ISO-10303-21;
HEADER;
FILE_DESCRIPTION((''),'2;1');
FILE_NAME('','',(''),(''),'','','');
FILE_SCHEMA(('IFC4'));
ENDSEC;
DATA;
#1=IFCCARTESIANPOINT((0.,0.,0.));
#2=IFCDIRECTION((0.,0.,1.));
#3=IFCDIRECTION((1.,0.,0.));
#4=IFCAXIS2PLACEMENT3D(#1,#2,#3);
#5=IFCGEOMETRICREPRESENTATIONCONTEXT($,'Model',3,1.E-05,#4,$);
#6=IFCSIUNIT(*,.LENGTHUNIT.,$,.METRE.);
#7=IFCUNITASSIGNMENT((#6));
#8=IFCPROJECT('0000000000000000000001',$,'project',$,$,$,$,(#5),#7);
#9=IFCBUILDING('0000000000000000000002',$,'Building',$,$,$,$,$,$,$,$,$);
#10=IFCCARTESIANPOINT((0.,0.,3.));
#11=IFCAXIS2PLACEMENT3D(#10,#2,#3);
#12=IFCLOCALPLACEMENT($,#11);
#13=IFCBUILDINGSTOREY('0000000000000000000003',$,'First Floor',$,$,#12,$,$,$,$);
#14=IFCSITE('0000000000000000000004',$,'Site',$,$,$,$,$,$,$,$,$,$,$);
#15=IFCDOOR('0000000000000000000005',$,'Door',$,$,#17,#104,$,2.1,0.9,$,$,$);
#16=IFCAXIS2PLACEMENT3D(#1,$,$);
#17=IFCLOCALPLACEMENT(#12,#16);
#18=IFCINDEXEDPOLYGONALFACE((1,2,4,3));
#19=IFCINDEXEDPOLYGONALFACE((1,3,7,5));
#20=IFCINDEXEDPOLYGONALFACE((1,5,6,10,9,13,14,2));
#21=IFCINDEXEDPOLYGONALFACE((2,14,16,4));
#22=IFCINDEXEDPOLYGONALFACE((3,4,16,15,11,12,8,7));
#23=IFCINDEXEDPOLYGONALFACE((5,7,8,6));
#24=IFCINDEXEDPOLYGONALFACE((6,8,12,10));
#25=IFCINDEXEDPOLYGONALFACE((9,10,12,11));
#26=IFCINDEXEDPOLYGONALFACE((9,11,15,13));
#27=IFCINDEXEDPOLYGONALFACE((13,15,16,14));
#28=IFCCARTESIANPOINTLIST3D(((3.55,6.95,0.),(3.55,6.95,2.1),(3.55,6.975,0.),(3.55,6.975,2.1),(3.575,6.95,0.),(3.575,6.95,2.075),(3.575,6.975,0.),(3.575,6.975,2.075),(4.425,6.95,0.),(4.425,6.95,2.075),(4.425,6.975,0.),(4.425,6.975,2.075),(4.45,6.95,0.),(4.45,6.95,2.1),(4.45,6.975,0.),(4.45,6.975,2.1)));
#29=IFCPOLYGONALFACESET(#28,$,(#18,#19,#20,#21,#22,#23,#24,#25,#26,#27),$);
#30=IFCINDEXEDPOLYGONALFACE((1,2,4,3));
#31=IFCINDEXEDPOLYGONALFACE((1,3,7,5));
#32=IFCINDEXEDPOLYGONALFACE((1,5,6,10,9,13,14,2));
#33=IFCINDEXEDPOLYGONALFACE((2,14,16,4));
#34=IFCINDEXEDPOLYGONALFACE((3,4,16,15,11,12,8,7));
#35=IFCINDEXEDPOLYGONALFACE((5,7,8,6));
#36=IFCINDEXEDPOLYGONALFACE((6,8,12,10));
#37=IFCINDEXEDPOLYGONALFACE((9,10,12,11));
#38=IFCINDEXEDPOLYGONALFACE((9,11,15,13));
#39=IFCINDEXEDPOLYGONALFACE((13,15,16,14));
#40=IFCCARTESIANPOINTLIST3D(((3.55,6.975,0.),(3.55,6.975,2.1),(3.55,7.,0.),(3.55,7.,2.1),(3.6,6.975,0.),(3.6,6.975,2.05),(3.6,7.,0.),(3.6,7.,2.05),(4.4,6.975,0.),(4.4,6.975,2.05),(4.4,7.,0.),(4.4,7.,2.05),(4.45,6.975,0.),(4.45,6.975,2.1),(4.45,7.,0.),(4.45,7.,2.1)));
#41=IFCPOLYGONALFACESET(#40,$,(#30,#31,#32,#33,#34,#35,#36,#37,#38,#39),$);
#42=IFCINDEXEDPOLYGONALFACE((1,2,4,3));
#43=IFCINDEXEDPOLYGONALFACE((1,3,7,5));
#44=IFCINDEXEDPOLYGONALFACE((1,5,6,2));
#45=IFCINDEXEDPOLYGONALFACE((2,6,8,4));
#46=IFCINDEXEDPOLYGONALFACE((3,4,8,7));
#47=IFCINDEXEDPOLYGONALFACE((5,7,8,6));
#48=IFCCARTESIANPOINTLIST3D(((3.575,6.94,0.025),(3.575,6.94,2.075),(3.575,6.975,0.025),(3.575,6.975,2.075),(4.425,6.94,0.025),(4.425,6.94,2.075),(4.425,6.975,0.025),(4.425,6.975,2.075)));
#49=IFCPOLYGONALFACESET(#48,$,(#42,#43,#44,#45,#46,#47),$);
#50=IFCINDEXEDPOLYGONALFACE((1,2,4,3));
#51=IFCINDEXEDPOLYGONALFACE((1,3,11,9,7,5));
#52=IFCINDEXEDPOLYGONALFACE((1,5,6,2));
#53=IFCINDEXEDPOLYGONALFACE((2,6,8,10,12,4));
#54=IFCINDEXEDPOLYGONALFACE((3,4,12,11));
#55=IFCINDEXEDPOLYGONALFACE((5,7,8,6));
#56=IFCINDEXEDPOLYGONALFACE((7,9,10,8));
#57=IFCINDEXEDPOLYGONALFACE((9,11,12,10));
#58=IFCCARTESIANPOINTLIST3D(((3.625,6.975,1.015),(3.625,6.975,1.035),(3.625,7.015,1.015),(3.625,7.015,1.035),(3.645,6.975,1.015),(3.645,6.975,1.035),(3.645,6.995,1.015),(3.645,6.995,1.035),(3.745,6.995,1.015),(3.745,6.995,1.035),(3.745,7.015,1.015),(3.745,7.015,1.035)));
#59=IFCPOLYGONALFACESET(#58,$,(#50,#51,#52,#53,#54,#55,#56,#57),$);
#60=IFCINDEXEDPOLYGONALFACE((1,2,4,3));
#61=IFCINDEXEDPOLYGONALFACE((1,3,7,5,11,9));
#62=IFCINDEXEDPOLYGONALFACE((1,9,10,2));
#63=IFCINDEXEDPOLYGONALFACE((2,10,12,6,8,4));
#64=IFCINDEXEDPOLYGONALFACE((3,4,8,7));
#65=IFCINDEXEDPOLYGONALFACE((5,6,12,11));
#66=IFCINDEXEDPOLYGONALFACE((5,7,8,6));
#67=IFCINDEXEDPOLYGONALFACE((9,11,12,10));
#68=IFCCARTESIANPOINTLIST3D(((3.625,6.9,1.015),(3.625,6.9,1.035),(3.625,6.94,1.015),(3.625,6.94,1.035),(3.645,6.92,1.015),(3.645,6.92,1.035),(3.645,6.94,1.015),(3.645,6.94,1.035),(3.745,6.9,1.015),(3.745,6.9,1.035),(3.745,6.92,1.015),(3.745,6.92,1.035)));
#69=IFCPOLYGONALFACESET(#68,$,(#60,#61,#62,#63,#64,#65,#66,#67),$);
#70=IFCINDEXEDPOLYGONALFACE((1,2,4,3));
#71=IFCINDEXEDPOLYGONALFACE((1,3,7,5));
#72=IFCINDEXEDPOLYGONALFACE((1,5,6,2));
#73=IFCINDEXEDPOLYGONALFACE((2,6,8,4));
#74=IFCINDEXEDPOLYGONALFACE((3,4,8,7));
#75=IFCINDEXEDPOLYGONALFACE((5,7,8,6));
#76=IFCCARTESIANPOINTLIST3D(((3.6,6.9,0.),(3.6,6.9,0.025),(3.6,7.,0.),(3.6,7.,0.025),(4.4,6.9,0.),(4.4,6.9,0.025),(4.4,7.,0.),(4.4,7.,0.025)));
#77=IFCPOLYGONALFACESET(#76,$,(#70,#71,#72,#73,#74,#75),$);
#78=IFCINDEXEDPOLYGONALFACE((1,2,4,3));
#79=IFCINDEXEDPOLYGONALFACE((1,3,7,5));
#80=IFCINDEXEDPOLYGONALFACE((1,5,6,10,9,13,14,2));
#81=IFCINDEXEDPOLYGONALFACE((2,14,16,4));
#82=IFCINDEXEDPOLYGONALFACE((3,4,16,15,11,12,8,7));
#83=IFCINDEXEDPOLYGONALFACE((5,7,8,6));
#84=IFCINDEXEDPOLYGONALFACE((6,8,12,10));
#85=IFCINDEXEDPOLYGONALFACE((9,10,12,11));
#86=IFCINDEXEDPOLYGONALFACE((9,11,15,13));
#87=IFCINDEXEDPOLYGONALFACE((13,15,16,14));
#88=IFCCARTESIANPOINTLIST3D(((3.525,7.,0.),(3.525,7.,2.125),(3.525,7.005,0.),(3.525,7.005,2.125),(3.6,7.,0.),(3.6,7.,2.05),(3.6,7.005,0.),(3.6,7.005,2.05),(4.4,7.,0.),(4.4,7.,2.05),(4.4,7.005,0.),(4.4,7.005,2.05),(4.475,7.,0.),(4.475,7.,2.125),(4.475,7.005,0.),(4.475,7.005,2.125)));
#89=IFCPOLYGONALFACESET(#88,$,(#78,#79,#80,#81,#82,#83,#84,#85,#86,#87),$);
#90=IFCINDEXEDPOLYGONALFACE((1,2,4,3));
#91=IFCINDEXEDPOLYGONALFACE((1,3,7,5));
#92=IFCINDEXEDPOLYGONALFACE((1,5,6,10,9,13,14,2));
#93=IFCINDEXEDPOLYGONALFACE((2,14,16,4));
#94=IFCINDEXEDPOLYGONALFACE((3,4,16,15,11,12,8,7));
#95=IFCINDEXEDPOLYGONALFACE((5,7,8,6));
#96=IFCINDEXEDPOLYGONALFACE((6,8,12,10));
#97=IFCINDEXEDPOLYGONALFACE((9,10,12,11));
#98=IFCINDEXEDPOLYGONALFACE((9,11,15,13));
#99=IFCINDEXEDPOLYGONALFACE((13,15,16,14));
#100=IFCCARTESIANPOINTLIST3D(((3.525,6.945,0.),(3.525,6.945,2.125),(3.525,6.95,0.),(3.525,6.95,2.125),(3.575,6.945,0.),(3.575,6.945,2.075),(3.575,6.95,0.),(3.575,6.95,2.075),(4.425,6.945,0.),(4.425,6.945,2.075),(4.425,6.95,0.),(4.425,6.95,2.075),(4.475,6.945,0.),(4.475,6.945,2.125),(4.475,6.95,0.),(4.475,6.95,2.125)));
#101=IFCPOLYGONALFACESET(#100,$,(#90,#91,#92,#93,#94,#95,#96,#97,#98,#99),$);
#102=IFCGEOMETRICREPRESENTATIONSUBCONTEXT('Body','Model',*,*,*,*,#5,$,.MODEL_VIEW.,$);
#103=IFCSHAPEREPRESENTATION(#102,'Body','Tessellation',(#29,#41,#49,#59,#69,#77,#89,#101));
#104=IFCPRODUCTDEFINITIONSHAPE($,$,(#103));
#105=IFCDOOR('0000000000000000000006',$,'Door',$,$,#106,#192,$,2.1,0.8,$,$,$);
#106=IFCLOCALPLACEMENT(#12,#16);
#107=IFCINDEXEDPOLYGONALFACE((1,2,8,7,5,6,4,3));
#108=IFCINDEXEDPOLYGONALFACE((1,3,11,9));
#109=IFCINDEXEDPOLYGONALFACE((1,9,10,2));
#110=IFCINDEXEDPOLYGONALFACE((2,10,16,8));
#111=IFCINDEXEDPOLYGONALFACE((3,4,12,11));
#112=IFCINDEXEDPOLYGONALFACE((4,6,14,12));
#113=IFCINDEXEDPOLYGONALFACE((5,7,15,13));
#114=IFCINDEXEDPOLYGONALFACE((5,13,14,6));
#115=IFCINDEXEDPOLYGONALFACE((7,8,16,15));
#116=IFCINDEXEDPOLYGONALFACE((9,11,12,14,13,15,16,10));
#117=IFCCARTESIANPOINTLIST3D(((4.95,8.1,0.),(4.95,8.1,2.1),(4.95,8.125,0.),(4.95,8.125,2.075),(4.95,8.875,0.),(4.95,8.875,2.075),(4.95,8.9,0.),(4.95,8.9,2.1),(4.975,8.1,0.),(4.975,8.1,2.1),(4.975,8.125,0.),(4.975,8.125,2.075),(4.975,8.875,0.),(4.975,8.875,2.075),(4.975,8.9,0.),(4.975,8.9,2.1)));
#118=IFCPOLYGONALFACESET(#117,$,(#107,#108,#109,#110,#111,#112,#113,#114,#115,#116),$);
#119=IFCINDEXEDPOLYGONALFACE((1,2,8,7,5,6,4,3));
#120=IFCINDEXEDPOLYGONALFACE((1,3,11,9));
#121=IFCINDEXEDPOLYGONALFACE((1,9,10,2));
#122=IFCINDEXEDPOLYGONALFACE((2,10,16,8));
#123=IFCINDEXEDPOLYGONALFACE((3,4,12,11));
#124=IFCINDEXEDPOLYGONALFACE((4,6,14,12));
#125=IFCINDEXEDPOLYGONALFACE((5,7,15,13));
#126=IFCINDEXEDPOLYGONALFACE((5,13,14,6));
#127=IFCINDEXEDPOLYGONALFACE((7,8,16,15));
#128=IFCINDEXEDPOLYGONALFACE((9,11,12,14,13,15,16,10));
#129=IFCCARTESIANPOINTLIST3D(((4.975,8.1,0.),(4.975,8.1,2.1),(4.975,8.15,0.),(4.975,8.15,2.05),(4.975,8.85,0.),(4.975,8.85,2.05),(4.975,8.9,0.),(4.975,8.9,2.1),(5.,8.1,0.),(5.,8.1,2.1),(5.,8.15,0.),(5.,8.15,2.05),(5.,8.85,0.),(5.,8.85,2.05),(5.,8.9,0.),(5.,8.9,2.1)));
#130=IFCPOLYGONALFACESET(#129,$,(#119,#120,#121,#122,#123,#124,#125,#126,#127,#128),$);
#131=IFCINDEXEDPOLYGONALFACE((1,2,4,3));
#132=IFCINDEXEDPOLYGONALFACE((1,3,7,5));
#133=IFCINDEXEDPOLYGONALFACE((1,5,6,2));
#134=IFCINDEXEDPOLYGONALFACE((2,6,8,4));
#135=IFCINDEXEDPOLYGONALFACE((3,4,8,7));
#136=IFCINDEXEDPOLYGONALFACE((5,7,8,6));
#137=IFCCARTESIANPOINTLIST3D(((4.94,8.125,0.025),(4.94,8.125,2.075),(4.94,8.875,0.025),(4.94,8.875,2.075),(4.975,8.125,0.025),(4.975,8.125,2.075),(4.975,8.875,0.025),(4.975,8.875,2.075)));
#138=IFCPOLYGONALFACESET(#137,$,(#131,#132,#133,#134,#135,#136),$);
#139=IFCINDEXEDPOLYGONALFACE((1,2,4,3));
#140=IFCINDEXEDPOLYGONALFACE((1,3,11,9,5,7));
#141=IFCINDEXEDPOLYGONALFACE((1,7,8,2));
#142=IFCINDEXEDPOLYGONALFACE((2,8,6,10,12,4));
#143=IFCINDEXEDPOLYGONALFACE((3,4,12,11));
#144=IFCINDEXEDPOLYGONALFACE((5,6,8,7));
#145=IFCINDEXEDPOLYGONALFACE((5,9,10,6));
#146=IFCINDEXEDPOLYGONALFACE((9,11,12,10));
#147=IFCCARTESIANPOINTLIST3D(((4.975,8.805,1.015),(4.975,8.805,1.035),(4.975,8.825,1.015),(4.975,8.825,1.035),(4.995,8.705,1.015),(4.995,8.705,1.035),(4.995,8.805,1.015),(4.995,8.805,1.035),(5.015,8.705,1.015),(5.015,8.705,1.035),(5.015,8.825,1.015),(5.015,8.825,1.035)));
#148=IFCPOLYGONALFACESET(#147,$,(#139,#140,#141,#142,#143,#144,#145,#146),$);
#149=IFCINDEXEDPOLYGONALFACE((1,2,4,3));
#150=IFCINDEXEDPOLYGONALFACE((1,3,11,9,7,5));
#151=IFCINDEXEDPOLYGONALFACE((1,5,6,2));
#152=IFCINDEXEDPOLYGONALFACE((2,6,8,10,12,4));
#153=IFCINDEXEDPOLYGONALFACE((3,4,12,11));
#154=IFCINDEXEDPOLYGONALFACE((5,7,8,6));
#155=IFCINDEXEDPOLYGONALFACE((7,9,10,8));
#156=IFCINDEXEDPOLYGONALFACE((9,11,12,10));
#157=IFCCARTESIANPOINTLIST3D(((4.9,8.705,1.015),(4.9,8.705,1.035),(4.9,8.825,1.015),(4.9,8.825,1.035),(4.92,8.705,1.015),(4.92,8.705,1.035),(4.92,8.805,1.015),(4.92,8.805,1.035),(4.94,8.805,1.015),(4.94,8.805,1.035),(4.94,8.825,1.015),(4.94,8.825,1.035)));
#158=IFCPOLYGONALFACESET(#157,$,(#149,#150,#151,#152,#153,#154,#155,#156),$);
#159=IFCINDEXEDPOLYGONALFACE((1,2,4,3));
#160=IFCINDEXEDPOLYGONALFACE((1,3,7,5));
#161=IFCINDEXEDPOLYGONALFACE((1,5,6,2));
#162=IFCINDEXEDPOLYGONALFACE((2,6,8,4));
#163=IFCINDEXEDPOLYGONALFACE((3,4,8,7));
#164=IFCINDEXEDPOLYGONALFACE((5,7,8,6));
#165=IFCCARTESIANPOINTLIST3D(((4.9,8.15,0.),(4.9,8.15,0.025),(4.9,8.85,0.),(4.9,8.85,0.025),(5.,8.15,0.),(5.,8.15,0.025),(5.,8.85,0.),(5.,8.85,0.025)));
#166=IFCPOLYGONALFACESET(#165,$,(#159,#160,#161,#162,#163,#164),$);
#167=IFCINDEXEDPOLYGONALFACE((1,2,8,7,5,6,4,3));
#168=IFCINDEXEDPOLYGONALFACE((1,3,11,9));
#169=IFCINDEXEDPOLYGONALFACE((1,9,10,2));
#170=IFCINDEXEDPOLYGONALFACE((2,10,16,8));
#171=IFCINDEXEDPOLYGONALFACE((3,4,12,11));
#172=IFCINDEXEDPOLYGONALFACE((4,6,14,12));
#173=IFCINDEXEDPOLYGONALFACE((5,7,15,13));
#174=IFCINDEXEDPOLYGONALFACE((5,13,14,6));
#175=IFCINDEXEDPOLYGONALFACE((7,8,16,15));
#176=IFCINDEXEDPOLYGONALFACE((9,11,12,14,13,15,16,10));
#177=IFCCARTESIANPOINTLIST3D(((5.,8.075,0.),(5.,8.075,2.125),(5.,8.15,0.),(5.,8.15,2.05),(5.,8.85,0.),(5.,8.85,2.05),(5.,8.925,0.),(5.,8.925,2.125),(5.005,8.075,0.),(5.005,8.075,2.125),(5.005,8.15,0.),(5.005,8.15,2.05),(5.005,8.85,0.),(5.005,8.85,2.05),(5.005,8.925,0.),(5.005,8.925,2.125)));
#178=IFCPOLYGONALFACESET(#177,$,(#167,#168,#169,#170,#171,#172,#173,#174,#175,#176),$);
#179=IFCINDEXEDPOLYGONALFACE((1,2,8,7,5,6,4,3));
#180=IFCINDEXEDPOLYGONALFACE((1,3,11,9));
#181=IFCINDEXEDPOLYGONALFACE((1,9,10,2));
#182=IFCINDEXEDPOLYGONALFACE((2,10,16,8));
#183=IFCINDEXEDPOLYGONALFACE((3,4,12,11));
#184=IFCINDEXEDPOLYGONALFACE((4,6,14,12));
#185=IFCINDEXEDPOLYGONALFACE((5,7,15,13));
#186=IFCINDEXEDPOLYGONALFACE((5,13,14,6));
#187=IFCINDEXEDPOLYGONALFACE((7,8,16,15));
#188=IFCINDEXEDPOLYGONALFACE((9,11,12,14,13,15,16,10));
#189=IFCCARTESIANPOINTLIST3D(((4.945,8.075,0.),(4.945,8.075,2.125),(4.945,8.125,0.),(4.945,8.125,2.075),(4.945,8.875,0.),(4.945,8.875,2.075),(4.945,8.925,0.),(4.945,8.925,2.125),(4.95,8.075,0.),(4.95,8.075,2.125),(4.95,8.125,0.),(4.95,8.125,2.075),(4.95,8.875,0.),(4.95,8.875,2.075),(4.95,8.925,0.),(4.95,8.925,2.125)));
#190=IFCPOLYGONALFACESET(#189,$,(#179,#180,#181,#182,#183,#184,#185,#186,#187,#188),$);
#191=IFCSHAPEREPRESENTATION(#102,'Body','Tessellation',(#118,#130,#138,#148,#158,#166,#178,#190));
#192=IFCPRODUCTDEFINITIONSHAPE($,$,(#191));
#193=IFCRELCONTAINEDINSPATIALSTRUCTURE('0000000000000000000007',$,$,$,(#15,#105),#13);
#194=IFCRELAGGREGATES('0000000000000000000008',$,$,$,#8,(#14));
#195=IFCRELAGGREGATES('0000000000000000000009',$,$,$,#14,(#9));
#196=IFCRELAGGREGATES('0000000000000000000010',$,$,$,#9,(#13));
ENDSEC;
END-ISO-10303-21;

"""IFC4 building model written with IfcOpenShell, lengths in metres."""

from ifc_helpers import new_model, si_unit, frame, origin_with_axes, place, context, subcontext, project, spatial, line, indexed_curve, outline, extrude, element, save


model = new_model("IFC4")

# Units and contexts
model_context = context("Model", 3, precision=1e-05, world=origin_with_axes())
body_context = subcontext(model_context, "Body", "Model", "MODEL_VIEW")
ifc_project = project(units=[si_unit("LENGTHUNIT", "METRE")], contexts=[model_context])

# Site, building, storey
site = spatial("IfcSite", under=ifc_project, Name="Site")
building = spatial("IfcBuilding", under=site, Name="Building")
storey_placement = place(None, frame((0.0, 0.0, 3.0), z_axis=(0.0, 0.0, 1.0), x_axis=(1.0, 0.0, 0.0)))
storey = spatial("IfcBuildingStorey", under=building, at=storey_placement, Name="First Floor")

# Doors
door_1_placement = place(storey_placement, frame((4.45, 7.0, 0.0), z_axis=(0.0, 0.0, 1.0), x_axis=(-1.0, 0.0, 0.0)))
element("IfcDoor", 1, at=door_1_placement, inside=storey, Name="Door", OverallHeight=2.1, OverallWidth=0.9, context=body_context, shape_type="SweptSolid", body=[
    extrude(outline(indexed_curve([(0.0, 0.0), (0.0, 2.1), (0.9, 2.1), (0.9, 0.0), (0.875, 0.0), (0.875, 2.075), (0.025, 2.075), (0.025, 0.0)], segments=[line(1, 2, 3, 4, 5, 6, 7, 8, 1)])), frame((0.0, 0.025, 0.0), z_axis=(0.0, -1.0, 0.0), x_axis=(1.0, 0.0, 0.0)), (0.0, 0.0, -1.0), 0.025),
    extrude(outline(indexed_curve([(0.0, 0.0), (0.0, 2.1), (0.9, 2.1), (0.9, 0.0), (0.85, 0.0), (0.85, 2.05), (0.05, 2.05), (0.05, 0.0)], segments=[line(1, 2, 3, 4, 5, 6, 7, 8, 1)])), frame((0.0, 0.0, 0.0), z_axis=(0.0, -1.0, 0.0), x_axis=(1.0, 0.0, 0.0)), (0.0, 0.0, -1.0), 0.025),
    extrude(outline(indexed_curve([(0.0, 0.0), (0.85, 0.0), (0.85, 0.035), (0.0, 0.035)], segments=[line(1, 2, 3, 4, 1)])), frame((0.025, 0.025, 0.025), z_axis=(0.0, 0.0, 1.0), x_axis=(1.0, 0.0, 0.0)), (0.0, 0.0, 1.0), 2.05),
    extrude(outline(indexed_curve([(0.0, 0.0), (0.0, -0.04), (-0.12, -0.04), (-0.12, -0.02), (-0.02, -0.02), (-0.02, 0.0)], segments=[line(1, 2, 3, 4, 5, 6, 1)])), frame((0.825, 0.025, 1.015), z_axis=(0.0, 0.0, 1.0), x_axis=(1.0, 0.0, 0.0)), (0.0, 0.0, 1.0), 0.02),
    extrude(outline(indexed_curve([(0.0, 0.0), (0.0, 0.04), (-0.12, 0.04), (-0.12, 0.02), (-0.02, 0.02), (-0.02, 0.0)], segments=[line(1, 2, 3, 4, 5, 6, 1)])), frame((0.825, 0.06, 1.015), z_axis=(0.0, 0.0, 1.0), x_axis=(1.0, 0.0, 0.0)), (0.0, 0.0, 1.0), 0.02),
    extrude(outline(indexed_curve([(0.0, 0.0), (0.8, 0.0), (0.8, 0.1), (0.0, 0.1)], segments=[line(1, 2, 3, 4, 1)])), frame((0.05, 0.0, 0.0), z_axis=(0.0, 0.0, 1.0), x_axis=(1.0, 0.0, 0.0)), (0.0, 0.0, 1.0), 0.025),
    extrude(outline(indexed_curve([(0.0, 0.0), (0.0, 2.125), (0.95, 2.125), (0.95, 0.0), (0.875, 0.0), (0.875, 2.05), (0.075, 2.05), (0.075, 0.0)], segments=[line(1, 2, 3, 4, 5, 6, 7, 8, 1)])), frame((-0.025, -0.005, 0.0), z_axis=(0.0, -1.0, 0.0), x_axis=(1.0, 0.0, 0.0)), (0.0, 0.0, -1.0), 0.005),
    extrude(outline(indexed_curve([(0.0, 0.0), (0.0, 2.125), (0.95, 2.125), (0.95, 0.0), (0.9, 0.0), (0.9, 2.075), (0.05, 2.075), (0.05, 0.0)], segments=[line(1, 2, 3, 4, 5, 6, 7, 8, 1)])), frame((-0.025, 0.05, 0.0), z_axis=(0.0, -1.0, 0.0), x_axis=(1.0, 0.0, 0.0)), (0.0, 0.0, -1.0), 0.005),
])
door_2_placement = place(storey_placement, frame((5.0, 8.1, 0.0), z_axis=(0.0, 0.0, 1.0), x_axis=(0.0, 1.0, 0.0)))
element("IfcDoor", 2, at=door_2_placement, inside=storey, Name="Door", OverallHeight=2.1, OverallWidth=0.8, context=body_context, shape_type="SweptSolid", body=[
    extrude(outline(indexed_curve([(0.0, 0.0), (0.0, 2.1), (0.8, 2.1), (0.8, 0.0), (0.775, 0.0), (0.775, 2.075), (0.025, 2.075), (0.025, 0.0)], segments=[line(1, 2, 3, 4, 5, 6, 7, 8, 1)])), frame((0.0, 0.025, 0.0), z_axis=(0.0, -1.0, 0.0), x_axis=(1.0, 0.0, 0.0)), (0.0, 0.0, -1.0), 0.025),
    extrude(outline(indexed_curve([(0.0, 0.0), (0.0, 2.1), (0.8, 2.1), (0.8, 0.0), (0.75, 0.0), (0.75, 2.05), (0.05, 2.05), (0.05, 0.0)], segments=[line(1, 2, 3, 4, 5, 6, 7, 8, 1)])), frame((0.0, 0.0, 0.0), z_axis=(0.0, -1.0, 0.0), x_axis=(1.0, 0.0, 0.0)), (0.0, 0.0, -1.0), 0.025),
    extrude(outline(indexed_curve([(0.0, 0.0), (0.75, 0.0), (0.75, 0.035), (0.0, 0.035)], segments=[line(1, 2, 3, 4, 1)])), frame((0.025, 0.025, 0.025), z_axis=(0.0, 0.0, 1.0), x_axis=(1.0, 0.0, 0.0)), (0.0, 0.0, 1.0), 2.05),
    extrude(outline(indexed_curve([(0.0, 0.0), (0.0, -0.04), (-0.12, -0.04), (-0.12, -0.02), (-0.02, -0.02), (-0.02, 0.0)], segments=[line(1, 2, 3, 4, 5, 6, 1)])), frame((0.725, 0.025, 1.015), z_axis=(0.0, 0.0, 1.0), x_axis=(1.0, 0.0, 0.0)), (0.0, 0.0, 1.0), 0.02),
    extrude(outline(indexed_curve([(0.0, 0.0), (0.0, 0.04), (-0.12, 0.04), (-0.12, 0.02), (-0.02, 0.02), (-0.02, 0.0)], segments=[line(1, 2, 3, 4, 5, 6, 1)])), frame((0.725, 0.06, 1.015), z_axis=(0.0, 0.0, 1.0), x_axis=(1.0, 0.0, 0.0)), (0.0, 0.0, 1.0), 0.02),
    extrude(outline(indexed_curve([(0.0, 0.0), (0.7, 0.0), (0.7, 0.1), (0.0, 0.1)], segments=[line(1, 2, 3, 4, 1)])), frame((0.05, 0.0, 0.0), z_axis=(0.0, 0.0, 1.0), x_axis=(1.0, 0.0, 0.0)), (0.0, 0.0, 1.0), 0.025),
    extrude(outline(indexed_curve([(0.0, 0.0), (0.0, 2.125), (0.85, 2.125), (0.85, 0.0), (0.775, 0.0), (0.775, 2.05), (0.075, 2.05), (0.075, 0.0)], segments=[line(1, 2, 3, 4, 5, 6, 7, 8, 1)])), frame((-0.025, -0.005, 0.0), z_axis=(0.0, -1.0, 0.0), x_axis=(1.0, 0.0, 0.0)), (0.0, 0.0, -1.0), 0.005),
    extrude(outline(indexed_curve([(0.0, 0.0), (0.0, 2.125), (0.85, 2.125), (0.85, 0.0), (0.8, 0.0), (0.8, 2.075), (0.05, 2.075), (0.05, 0.0)], segments=[line(1, 2, 3, 4, 5, 6, 7, 8, 1)])), frame((-0.025, 0.05, 0.0), z_axis=(0.0, -1.0, 0.0), x_axis=(1.0, 0.0, 0.0)), (0.0, 0.0, -1.0), 0.005),
])

save(model, "model.ifc")
